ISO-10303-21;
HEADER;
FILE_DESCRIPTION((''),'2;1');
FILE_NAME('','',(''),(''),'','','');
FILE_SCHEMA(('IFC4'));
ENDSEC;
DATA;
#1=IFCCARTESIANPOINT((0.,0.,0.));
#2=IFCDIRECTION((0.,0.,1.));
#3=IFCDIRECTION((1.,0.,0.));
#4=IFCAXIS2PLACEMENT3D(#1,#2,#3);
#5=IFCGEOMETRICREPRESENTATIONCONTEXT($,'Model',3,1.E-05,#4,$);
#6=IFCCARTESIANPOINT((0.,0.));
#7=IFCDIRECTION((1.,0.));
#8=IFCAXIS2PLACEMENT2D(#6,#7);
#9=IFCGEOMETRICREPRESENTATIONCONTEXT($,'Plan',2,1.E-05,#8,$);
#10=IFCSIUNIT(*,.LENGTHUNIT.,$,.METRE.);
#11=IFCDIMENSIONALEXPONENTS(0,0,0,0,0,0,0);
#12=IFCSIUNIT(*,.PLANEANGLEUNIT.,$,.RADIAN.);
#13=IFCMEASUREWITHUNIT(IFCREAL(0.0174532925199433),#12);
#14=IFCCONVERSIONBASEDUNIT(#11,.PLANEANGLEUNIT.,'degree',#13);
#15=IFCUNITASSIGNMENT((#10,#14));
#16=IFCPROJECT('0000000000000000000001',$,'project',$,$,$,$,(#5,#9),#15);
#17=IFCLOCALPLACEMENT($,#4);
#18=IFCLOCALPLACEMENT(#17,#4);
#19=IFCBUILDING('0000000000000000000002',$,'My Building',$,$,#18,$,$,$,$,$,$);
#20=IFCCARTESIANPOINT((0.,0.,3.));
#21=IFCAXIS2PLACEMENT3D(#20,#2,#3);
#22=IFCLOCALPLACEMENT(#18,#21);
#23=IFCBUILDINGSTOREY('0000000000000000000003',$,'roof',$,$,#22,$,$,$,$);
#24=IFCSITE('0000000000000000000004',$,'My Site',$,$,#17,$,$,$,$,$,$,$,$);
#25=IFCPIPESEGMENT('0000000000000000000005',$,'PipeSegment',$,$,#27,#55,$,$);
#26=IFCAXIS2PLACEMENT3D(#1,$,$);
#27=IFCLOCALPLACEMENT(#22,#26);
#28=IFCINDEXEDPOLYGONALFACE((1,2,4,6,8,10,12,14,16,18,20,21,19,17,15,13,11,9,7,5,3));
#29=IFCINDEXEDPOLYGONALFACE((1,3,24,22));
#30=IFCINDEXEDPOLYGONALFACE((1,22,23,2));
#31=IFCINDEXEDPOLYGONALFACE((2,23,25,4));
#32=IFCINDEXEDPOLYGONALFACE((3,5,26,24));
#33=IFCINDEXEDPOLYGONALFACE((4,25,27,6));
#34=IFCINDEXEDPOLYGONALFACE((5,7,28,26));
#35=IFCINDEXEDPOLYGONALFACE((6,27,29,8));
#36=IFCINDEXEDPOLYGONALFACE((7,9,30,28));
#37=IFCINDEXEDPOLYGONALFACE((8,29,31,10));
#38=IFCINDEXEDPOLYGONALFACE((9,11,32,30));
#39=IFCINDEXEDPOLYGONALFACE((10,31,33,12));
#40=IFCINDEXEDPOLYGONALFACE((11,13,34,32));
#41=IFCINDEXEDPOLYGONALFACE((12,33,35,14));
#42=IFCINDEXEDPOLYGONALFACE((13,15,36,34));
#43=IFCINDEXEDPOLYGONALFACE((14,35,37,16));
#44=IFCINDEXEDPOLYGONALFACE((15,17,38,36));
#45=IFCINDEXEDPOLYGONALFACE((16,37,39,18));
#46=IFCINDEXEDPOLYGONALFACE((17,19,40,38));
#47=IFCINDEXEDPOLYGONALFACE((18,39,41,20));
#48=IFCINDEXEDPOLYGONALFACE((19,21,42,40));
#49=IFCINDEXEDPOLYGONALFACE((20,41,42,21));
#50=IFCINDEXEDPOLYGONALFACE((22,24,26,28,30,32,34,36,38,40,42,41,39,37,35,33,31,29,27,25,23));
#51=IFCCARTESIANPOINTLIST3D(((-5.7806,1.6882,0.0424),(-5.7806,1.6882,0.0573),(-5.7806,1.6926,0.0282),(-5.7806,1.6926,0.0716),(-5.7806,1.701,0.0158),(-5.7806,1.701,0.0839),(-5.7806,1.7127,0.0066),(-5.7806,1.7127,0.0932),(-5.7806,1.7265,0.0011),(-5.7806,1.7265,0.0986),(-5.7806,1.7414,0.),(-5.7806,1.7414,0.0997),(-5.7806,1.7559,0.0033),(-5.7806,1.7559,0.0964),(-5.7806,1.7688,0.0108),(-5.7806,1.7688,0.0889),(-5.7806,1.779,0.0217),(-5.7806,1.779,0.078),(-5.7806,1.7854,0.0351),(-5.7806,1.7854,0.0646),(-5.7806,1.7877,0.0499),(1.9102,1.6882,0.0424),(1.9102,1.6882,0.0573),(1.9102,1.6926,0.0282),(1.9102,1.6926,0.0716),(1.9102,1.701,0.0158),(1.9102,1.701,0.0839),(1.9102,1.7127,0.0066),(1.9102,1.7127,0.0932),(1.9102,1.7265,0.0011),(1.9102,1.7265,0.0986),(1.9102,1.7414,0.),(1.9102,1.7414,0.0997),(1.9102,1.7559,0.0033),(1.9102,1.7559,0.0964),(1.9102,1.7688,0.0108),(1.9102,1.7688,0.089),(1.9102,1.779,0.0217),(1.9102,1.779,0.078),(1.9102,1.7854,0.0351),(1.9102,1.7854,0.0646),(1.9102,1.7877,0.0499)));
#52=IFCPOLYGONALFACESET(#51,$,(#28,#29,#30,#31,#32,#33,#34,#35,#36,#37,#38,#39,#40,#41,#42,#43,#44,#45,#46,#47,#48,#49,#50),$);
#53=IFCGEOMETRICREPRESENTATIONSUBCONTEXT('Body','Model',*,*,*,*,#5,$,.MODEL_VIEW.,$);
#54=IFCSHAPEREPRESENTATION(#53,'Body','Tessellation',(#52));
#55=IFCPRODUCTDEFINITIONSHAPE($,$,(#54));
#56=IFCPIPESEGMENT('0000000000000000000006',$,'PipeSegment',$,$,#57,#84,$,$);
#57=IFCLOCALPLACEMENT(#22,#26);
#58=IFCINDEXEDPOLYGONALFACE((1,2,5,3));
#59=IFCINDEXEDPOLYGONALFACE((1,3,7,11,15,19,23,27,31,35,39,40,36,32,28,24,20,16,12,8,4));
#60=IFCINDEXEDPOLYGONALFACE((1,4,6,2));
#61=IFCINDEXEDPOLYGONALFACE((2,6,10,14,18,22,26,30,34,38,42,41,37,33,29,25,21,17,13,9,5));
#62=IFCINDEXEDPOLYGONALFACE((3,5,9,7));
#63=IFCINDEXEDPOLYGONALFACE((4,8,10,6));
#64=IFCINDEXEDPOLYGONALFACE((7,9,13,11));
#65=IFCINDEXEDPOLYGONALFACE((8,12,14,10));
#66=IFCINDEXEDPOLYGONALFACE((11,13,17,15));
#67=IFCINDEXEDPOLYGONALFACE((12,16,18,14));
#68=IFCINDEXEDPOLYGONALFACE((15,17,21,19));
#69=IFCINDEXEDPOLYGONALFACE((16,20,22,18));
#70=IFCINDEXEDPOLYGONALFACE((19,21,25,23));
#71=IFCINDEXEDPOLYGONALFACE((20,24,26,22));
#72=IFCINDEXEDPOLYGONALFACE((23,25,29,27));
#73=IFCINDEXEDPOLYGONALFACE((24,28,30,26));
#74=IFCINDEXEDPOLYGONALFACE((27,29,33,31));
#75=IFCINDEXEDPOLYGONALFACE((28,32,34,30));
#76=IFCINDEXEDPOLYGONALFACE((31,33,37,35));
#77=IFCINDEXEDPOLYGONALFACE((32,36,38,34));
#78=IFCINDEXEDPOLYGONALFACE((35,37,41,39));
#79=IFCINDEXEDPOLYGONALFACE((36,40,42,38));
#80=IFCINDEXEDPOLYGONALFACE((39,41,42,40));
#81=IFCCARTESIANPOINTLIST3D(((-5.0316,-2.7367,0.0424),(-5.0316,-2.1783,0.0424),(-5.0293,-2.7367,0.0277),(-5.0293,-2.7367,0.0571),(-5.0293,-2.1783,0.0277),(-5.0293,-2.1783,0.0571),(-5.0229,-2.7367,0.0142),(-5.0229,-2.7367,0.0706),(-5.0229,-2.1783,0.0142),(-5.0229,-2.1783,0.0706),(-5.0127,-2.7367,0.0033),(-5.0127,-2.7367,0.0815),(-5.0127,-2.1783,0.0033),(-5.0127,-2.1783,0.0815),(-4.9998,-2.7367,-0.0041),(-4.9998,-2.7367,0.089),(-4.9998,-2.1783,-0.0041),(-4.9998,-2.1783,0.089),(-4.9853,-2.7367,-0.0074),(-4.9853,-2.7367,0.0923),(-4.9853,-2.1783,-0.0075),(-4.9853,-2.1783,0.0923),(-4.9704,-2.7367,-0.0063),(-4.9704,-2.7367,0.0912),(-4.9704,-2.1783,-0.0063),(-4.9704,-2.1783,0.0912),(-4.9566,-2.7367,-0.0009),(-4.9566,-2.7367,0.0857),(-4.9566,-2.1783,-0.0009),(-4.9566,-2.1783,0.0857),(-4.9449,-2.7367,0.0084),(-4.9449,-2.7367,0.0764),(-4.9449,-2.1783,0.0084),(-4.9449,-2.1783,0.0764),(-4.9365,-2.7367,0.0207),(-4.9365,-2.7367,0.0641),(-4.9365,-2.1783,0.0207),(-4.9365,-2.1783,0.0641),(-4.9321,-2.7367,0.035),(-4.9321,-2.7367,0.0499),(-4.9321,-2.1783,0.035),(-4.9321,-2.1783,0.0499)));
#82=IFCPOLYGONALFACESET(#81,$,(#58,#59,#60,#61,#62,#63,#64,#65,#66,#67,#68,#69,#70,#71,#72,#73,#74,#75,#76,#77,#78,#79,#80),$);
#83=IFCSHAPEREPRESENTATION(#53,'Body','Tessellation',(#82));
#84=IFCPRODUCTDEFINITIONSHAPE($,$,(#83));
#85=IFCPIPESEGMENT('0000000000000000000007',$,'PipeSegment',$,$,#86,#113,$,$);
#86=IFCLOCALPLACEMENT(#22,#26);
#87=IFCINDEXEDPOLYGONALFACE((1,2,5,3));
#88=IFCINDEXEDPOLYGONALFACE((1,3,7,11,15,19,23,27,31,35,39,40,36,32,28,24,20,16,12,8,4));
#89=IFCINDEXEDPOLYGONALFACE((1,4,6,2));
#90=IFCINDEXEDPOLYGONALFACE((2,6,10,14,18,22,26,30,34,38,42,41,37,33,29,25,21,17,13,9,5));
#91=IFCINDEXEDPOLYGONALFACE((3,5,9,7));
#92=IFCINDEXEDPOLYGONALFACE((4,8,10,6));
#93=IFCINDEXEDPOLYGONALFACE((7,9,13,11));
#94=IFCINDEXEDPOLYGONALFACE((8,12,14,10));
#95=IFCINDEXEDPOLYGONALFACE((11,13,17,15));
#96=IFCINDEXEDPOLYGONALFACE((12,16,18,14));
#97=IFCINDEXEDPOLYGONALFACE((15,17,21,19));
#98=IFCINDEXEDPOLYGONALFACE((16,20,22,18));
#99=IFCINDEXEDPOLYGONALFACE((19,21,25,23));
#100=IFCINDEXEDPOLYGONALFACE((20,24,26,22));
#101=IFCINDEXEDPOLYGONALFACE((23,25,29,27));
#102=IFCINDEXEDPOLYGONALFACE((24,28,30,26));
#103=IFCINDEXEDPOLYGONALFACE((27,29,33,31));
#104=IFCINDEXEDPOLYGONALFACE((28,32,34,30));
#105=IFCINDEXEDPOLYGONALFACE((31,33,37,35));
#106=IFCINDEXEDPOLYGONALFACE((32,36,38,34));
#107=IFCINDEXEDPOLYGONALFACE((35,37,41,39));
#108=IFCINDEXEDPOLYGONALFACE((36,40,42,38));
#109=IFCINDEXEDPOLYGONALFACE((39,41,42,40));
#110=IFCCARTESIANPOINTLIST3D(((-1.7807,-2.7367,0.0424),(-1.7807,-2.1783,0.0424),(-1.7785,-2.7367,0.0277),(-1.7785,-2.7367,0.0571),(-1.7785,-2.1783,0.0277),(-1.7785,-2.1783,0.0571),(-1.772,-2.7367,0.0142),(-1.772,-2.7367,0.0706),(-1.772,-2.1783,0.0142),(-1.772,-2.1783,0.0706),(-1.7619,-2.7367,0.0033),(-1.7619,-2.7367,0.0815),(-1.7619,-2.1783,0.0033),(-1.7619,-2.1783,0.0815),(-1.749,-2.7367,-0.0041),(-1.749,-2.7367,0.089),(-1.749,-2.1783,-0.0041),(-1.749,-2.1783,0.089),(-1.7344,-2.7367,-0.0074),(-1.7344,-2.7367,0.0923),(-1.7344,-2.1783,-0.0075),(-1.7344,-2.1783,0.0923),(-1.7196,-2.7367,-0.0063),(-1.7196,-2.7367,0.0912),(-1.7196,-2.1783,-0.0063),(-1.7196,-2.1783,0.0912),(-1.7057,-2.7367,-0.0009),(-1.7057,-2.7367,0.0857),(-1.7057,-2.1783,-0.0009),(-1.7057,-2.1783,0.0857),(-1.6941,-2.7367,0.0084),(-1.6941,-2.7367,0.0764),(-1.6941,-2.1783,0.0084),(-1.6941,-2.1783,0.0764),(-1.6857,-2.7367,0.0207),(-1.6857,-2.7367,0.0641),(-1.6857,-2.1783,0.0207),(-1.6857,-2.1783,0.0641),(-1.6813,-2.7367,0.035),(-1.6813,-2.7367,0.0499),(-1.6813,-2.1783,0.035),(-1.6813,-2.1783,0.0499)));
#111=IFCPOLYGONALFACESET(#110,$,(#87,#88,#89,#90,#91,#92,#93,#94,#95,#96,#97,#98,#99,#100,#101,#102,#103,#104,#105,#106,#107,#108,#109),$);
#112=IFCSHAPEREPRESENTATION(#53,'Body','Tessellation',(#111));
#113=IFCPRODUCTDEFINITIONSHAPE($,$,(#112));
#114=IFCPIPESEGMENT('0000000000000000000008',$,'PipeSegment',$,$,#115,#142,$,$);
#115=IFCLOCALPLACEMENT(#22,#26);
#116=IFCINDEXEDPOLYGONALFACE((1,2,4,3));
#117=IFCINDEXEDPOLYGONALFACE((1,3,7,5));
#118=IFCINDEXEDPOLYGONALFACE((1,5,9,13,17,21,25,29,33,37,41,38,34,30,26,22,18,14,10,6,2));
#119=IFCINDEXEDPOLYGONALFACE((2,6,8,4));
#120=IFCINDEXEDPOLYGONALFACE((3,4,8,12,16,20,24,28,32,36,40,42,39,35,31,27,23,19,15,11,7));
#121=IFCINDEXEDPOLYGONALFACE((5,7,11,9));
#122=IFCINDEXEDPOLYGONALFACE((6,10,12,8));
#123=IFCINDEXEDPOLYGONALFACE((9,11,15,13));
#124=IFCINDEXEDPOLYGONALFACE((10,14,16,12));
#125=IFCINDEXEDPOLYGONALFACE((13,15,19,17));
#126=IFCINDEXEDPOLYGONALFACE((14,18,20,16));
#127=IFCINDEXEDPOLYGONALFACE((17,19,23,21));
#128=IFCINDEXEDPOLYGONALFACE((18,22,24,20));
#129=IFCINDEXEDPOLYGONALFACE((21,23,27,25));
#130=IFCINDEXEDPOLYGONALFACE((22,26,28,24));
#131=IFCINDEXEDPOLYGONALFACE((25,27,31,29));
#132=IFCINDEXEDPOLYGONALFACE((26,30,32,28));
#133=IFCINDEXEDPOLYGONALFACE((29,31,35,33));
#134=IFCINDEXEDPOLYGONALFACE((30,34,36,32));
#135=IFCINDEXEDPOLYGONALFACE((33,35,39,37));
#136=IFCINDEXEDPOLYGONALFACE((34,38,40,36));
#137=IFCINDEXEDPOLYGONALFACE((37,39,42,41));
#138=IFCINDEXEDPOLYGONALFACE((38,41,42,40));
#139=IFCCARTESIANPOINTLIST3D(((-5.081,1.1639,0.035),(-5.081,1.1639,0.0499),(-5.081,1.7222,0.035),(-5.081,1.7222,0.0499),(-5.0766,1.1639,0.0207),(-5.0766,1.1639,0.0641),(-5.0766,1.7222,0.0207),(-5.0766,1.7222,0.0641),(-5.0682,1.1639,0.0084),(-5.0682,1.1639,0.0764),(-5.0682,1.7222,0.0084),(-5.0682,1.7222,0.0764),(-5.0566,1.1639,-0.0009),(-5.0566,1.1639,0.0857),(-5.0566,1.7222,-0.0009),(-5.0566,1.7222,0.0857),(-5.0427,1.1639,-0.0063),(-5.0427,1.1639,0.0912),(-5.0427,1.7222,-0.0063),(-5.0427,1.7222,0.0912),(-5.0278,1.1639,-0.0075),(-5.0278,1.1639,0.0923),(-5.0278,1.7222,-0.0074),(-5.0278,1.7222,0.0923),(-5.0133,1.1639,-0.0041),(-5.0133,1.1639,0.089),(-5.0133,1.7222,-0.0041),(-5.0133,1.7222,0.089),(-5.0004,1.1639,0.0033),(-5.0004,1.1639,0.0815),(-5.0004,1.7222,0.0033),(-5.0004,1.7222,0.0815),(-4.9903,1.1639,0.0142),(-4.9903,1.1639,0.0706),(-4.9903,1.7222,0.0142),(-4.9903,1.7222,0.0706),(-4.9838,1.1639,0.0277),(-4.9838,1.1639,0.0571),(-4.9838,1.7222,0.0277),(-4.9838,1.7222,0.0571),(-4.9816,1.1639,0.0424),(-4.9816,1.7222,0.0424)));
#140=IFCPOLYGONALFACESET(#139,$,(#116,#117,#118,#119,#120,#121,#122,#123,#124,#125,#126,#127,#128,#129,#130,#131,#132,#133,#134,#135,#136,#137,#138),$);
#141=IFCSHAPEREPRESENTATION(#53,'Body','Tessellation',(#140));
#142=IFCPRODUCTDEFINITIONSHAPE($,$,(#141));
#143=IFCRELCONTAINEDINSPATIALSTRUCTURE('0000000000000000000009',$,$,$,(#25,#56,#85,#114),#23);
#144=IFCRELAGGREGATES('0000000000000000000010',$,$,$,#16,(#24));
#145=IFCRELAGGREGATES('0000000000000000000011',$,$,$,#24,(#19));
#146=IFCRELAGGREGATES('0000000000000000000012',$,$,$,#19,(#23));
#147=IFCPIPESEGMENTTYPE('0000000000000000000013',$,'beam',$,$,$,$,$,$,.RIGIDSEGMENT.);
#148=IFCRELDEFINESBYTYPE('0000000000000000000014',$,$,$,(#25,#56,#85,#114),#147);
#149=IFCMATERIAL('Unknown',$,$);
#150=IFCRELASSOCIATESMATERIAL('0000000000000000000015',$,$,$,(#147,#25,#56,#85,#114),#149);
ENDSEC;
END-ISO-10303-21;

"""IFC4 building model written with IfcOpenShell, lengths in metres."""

from ifc_helpers import new_model, entity, si_unit, converted_unit, frame, origin_with_axes, origin_2d_with_axis, place, context, subcontext, project, spatial, circle, extrude, material, material_profile, profile_set, profile_usage, type_object, element, save


model = new_model("IFC4")

# Units and contexts
model_context = context("Model", 3, precision=1e-05, world=origin_with_axes())
plan_context = context("Plan", 2, precision=1e-05, world=origin_2d_with_axis())
body_context = subcontext(model_context, "Body", "Model", "MODEL_VIEW")
ifc_project = project(units=[si_unit("LENGTHUNIT", "METRE"), converted_unit("PLANEANGLEUNIT", "degree", entity("IfcReal", 0.0174532925199433), si_unit("PLANEANGLEUNIT", "RADIAN"), dimensions=[0, 0, 0, 0, 0, 0, 0])], contexts=[model_context, plan_context])

# Site, building, storey
site_placement = place(None, origin_with_axes())
site = spatial("IfcSite", under=ifc_project, at=site_placement, Name="My Site")
building_placement = place(site_placement, origin_with_axes())
building = spatial("IfcBuilding", under=site, at=building_placement, Name="My Building")
storey_placement = place(building_placement, frame((0.0, 0.0, 3.0), z_axis=(0.0, 0.0, 1.0), x_axis=(1.0, 0.0, 0.0)))
storey = spatial("IfcBuildingStorey", under=building, at=storey_placement, Name="roof")

# Shared definitions
ifc_material = material(Name="Unknown")

# Pipe segments
ifc_material_profile_1 = material_profile(ifc_material, circle(Radius=0.05))
ifc_profile_set_1 = profile_set([ifc_material_profile_1])
pipe_segment_type = type_object("IfcPipeSegmentType", Name="beam", PredefinedType="RIGIDSEGMENT", material=ifc_profile_set_1)
ifc_profile_usage_1 = profile_usage(ifc_profile_set_1, cardinal=7)
pipe_segment_1_placement = place(storey_placement, frame((-5.7806, 1.7877, 0.0999), z_axis=(1.0, 0.0, 0.0), x_axis=(0.0, 1.0, 0.0)))
element("IfcPipeSegment", 1, at=pipe_segment_1_placement, inside=storey, type_object=pipe_segment_type, material=ifc_profile_usage_1, Name="PipeSegment", context=body_context, shape_type="SweptSolid", body=[
    extrude(circle(Radius=0.05), frame((-0.05, -0.05, 0.0), z_axis=(0.0, 0.0, 1.0), x_axis=(1.0, 0.0, 0.0)), (0.0, 0.0, 1.0), 7.6908),
])
ifc_profile_usage_2 = profile_usage(ifc_profile_set_1, cardinal=7)
pipe_segment_2_placement = place(storey_placement, frame((-5.0316, -2.7367, 0.0924), z_axis=(0.0, 1.0, -0.000008), x_axis=(-1.0, 0.0, 0.0)))
element("IfcPipeSegment", 2, at=pipe_segment_2_placement, inside=storey, type_object=pipe_segment_type, material=ifc_profile_usage_2, Name="PipeSegment", context=body_context, shape_type="SweptSolid", body=[
    extrude(circle(Radius=0.05), frame((-0.05, -0.05, 0.0), z_axis=(0.0, 0.0, 1.0), x_axis=(1.0, 0.0, 0.0)), (0.0, 0.0, 1.0), 0.5584),
])
ifc_profile_usage_3 = profile_usage(ifc_profile_set_1, cardinal=7)
pipe_segment_3_placement = place(storey_placement, frame((-1.7807, -2.7367, 0.0924), z_axis=(0.0, 1.0, -0.000008), x_axis=(-1.0, 0.0, 0.0)))
element("IfcPipeSegment", 3, at=pipe_segment_3_placement, inside=storey, type_object=pipe_segment_type, material=ifc_profile_usage_3, Name="PipeSegment", context=body_context, shape_type="SweptSolid", body=[
    extrude(circle(Radius=0.05), frame((-0.05, -0.05, 0.0), z_axis=(0.0, 0.0, 1.0), x_axis=(1.0, 0.0, 0.0)), (0.0, 0.0, 1.0), 0.5584),
])
ifc_profile_usage_4 = profile_usage(ifc_profile_set_1, cardinal=7)
pipe_segment_4_placement = place(storey_placement, frame((-4.9816, 1.7222, 0.0924), z_axis=(0.0, -1.0, -0.000008), x_axis=(1.0, 0.0, 0.0)))
element("IfcPipeSegment", 4, at=pipe_segment_4_placement, inside=storey, type_object=pipe_segment_type, material=ifc_profile_usage_4, Name="PipeSegment", context=body_context, shape_type="SweptSolid", body=[
    extrude(circle(Radius=0.05), frame((-0.05, -0.05, 0.0), z_axis=(0.0, 0.0, 1.0), x_axis=(1.0, 0.0, 0.0)), (0.0, 0.0, 1.0), 0.5584),
])

save(model, "model.ifc")
